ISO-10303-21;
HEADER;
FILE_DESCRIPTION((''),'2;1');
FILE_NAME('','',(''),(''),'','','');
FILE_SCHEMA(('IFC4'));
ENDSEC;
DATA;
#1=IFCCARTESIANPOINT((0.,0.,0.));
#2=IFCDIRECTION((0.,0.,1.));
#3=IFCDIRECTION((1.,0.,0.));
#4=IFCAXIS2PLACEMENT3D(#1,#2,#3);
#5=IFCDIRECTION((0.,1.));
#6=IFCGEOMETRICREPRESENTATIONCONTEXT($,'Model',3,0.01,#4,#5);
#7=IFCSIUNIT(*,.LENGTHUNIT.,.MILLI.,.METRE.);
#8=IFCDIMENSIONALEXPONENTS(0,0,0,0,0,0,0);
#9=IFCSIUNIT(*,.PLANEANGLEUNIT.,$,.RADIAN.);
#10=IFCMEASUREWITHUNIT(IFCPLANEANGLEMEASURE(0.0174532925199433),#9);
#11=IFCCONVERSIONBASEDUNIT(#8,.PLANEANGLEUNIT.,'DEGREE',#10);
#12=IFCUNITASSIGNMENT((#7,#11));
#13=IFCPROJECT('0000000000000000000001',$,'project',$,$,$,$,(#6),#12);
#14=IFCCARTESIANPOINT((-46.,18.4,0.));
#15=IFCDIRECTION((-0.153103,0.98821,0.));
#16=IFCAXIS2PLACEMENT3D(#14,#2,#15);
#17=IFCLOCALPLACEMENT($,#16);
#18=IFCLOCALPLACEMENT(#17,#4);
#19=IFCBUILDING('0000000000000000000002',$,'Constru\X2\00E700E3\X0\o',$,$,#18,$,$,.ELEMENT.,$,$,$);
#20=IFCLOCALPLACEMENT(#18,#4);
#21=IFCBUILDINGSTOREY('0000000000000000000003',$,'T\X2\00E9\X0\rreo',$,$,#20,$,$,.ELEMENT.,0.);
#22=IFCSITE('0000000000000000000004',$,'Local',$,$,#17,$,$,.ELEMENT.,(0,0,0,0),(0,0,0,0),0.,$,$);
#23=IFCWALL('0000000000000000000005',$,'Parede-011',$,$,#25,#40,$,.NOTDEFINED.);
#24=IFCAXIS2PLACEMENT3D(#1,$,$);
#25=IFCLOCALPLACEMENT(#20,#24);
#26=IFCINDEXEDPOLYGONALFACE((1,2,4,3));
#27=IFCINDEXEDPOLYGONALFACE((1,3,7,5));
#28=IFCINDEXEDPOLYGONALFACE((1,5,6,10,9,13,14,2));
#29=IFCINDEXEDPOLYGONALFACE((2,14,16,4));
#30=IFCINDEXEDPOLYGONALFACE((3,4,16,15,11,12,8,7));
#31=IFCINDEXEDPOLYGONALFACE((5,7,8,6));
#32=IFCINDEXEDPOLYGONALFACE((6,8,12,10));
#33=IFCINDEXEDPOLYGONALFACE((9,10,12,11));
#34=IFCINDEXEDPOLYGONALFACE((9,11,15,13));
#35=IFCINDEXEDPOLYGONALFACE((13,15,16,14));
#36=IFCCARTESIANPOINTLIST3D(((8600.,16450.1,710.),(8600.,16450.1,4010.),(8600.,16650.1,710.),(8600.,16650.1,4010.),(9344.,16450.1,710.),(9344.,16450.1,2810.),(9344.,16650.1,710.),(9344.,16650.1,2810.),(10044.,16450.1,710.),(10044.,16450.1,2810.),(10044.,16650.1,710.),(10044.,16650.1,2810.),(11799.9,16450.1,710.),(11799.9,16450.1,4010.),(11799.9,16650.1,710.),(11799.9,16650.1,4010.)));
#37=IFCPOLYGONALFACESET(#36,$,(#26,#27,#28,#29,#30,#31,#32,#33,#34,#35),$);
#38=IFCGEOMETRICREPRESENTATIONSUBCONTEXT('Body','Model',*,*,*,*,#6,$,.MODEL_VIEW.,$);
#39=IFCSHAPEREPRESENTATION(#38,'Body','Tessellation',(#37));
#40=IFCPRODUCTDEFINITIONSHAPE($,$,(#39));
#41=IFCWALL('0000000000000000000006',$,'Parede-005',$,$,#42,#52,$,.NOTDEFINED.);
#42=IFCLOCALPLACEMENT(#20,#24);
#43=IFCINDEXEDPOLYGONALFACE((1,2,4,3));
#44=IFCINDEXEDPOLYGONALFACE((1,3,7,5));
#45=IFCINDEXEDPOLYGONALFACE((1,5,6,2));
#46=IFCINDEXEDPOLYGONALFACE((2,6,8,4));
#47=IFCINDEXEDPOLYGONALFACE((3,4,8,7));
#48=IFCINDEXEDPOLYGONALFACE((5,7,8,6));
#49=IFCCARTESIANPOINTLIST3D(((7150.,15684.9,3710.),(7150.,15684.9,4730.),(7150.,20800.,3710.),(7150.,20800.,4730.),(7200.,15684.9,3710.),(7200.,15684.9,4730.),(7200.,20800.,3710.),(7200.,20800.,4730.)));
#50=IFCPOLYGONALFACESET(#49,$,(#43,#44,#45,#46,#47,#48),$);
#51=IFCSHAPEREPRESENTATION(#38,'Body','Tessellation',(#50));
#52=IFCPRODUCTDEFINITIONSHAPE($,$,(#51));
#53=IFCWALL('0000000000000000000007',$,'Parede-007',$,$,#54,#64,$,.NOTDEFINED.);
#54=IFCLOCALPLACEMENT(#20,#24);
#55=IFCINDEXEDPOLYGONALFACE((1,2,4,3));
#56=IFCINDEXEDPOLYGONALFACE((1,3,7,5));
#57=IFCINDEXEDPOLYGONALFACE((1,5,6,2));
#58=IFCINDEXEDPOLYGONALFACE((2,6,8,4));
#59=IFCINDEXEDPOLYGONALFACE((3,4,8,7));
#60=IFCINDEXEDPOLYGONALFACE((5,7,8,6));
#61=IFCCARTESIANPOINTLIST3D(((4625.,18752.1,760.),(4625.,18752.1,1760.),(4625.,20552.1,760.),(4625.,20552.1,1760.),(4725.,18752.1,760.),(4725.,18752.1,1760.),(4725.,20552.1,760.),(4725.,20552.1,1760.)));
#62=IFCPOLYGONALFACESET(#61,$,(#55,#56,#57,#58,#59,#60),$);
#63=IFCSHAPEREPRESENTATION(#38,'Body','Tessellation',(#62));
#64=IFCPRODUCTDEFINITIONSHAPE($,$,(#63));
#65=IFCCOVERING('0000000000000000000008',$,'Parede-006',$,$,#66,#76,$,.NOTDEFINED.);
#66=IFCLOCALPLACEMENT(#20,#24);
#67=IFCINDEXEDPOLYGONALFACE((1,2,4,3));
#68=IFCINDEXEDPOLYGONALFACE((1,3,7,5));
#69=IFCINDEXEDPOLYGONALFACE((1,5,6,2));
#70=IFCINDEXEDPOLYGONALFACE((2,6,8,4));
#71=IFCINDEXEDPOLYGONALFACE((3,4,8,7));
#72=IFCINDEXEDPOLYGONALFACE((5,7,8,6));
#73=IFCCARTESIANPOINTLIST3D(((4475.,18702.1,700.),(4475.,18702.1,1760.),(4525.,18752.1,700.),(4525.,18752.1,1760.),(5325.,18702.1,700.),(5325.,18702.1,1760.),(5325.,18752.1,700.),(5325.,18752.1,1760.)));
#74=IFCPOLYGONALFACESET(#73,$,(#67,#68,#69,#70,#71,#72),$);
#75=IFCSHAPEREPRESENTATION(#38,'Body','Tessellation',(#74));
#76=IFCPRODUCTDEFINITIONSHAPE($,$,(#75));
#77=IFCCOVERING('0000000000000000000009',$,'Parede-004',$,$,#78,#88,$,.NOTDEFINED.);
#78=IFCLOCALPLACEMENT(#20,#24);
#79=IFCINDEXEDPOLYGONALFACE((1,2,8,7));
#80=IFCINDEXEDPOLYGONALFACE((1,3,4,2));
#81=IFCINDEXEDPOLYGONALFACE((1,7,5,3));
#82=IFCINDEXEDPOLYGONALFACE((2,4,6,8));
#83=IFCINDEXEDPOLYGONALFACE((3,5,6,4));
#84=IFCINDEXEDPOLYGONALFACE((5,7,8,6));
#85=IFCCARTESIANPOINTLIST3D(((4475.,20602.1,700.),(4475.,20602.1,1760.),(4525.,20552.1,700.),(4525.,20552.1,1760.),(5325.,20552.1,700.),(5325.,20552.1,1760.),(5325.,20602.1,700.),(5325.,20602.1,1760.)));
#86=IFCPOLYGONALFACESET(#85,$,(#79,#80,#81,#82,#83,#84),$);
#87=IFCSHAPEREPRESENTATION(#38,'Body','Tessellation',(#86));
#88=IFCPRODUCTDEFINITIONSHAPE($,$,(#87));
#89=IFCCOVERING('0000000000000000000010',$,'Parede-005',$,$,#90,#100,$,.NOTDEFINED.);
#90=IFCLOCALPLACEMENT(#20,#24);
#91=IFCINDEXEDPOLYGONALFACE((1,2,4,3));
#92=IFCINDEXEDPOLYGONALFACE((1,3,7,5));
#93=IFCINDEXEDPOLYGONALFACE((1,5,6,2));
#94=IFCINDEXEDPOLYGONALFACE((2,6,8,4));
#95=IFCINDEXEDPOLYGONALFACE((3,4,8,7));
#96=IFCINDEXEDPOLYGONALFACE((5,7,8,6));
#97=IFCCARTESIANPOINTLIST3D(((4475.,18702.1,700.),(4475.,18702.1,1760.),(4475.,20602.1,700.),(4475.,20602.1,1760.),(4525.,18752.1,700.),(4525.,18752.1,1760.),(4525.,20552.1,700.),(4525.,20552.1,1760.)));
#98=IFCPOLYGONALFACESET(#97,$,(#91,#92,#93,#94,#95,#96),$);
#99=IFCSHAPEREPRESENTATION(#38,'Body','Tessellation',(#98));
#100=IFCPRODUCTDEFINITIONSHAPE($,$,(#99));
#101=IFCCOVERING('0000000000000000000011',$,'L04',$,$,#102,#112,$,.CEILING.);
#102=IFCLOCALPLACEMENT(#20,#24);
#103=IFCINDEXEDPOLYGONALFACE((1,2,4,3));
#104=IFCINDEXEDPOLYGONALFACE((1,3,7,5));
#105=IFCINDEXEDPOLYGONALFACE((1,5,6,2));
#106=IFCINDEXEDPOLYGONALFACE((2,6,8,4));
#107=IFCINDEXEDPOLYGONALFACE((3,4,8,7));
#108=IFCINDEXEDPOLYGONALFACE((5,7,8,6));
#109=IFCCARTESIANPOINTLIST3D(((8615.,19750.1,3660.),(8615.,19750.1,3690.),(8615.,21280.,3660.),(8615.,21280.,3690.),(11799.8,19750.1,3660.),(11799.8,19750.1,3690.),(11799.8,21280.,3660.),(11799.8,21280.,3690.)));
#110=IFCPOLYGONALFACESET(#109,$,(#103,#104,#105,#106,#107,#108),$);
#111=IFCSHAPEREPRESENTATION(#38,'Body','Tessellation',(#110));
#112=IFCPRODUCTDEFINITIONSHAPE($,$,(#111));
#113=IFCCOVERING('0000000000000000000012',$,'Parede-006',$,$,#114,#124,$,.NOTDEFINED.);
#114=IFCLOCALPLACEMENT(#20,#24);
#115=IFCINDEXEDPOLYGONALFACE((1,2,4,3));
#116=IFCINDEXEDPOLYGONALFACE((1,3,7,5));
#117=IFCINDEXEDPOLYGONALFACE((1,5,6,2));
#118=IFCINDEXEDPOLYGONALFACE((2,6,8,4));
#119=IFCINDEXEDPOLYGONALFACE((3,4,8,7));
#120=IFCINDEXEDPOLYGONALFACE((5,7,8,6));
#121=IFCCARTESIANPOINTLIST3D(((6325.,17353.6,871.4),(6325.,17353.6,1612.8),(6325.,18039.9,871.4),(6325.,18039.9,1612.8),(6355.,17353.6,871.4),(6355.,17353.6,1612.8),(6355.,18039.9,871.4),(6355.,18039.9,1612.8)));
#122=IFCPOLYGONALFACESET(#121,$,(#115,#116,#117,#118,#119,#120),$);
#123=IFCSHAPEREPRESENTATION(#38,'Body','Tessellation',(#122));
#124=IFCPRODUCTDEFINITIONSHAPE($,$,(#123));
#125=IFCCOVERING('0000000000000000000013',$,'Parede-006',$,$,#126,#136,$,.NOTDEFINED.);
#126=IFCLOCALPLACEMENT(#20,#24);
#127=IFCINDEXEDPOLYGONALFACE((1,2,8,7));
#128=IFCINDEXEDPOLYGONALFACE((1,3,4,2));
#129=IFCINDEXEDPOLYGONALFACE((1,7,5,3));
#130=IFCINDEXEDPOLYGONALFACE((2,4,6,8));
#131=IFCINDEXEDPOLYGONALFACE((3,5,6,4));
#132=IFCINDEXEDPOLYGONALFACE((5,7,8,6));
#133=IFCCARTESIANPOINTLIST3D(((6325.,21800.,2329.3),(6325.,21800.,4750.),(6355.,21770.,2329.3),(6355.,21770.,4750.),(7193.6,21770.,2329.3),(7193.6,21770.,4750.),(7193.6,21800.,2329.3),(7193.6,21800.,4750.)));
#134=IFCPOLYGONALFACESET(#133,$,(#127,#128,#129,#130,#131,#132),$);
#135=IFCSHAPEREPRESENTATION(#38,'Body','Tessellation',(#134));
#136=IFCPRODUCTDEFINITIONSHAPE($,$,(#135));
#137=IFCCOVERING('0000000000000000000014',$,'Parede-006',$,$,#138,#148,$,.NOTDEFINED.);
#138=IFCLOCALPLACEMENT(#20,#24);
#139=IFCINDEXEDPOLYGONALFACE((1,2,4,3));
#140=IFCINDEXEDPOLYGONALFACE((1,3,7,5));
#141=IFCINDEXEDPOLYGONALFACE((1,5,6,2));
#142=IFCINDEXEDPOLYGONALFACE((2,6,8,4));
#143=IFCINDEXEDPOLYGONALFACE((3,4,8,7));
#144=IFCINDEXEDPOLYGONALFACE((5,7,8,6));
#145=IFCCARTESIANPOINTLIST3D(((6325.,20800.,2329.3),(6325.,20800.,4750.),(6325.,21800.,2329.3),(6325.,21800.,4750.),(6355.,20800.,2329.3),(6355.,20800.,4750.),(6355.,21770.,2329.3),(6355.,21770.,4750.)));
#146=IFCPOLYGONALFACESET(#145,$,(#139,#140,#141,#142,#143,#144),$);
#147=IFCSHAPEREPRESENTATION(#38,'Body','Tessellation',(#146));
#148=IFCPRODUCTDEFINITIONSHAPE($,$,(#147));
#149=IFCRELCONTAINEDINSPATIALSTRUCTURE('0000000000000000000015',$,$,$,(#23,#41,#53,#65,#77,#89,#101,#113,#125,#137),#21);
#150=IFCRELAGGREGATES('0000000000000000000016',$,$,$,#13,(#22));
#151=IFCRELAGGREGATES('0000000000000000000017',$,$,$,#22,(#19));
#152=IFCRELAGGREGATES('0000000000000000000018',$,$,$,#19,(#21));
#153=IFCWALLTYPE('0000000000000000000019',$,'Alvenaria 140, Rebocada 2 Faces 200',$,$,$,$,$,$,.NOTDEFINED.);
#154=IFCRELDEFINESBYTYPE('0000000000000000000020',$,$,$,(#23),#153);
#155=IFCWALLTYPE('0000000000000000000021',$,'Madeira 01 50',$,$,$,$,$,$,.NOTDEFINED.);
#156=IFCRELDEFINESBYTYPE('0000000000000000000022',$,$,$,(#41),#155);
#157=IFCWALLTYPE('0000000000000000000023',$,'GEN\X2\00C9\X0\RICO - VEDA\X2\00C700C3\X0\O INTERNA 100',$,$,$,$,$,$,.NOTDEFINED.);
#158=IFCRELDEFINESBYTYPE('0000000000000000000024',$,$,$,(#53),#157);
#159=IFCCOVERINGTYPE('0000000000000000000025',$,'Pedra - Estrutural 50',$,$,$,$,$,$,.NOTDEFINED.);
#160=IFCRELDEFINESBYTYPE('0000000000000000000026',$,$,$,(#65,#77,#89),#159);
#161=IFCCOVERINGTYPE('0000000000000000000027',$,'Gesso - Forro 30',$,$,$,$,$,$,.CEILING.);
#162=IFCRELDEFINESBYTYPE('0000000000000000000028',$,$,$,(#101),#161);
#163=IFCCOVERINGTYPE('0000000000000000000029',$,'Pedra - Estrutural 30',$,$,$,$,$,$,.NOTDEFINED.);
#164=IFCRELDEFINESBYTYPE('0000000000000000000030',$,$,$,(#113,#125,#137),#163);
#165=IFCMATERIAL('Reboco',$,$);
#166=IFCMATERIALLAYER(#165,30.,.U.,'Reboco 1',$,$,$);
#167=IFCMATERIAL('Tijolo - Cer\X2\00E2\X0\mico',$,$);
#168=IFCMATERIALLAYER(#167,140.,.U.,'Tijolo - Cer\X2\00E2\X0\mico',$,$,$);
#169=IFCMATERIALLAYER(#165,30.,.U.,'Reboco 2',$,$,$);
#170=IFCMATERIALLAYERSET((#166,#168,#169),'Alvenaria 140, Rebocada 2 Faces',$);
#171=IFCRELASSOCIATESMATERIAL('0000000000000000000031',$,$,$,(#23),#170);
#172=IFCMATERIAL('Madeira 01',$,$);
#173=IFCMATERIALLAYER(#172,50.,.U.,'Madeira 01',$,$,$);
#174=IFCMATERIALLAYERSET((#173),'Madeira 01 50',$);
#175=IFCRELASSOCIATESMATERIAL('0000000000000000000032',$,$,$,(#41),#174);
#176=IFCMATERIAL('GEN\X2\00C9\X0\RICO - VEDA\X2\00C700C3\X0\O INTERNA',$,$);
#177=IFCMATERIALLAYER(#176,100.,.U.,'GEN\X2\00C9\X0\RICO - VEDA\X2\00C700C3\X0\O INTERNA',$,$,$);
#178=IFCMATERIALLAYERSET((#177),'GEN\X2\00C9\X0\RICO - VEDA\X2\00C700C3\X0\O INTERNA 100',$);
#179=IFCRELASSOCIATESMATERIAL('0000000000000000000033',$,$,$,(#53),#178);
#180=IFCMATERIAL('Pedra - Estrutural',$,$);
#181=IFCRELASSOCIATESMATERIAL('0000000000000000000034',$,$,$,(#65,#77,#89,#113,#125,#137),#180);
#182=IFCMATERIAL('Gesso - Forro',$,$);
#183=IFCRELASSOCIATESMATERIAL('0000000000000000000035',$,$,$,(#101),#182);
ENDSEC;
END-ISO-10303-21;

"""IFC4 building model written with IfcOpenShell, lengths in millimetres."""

from ifc_helpers import new_model, entity, si_unit, converted_unit, direction, frame, origin_with_axes, origin_2d_with_axis, place, context, subcontext, project, spatial, line, indexed_curve, rectangle, outline, extrude, material, layer, layer_set, layer_usage, type_object, element, save


model = new_model("IFC4")

# Units and contexts
model_context = context("Model", 3, precision=0.01, world=origin_with_axes(), true_north=direction((0.0, 1.0)))
body_context = subcontext(model_context, "Body", "Model", "MODEL_VIEW")
ifc_project = project(units=[si_unit("LENGTHUNIT", "METRE", prefix="MILLI"), converted_unit("PLANEANGLEUNIT", "DEGREE", entity("IfcPlaneAngleMeasure", 0.0174532925199433), si_unit("PLANEANGLEUNIT", "RADIAN"), dimensions=[0, 0, 0, 0, 0, 0, 0])], contexts=[model_context])

# Site, building, storey
site_placement = place(None, frame((-46.0, 18.4, 0.0), z_axis=(0.0, 0.0, 1.0), x_axis=(-0.153103, 0.98821, 0.0)))
site = spatial("IfcSite", under=ifc_project, at=site_placement, Name="Local", CompositionType="ELEMENT", RefLatitude=(0, 0, 0, 0), RefLongitude=(0, 0, 0, 0), RefElevation=0.0)
building_placement = place(site_placement, origin_with_axes())
building = spatial("IfcBuilding", under=site, at=building_placement, Name="Construção", CompositionType="ELEMENT")
storey_placement = place(building_placement, origin_with_axes())
storey = spatial("IfcBuildingStorey", under=building, at=storey_placement, Name="Térreo", CompositionType="ELEMENT", Elevation=0.0)

# Wall, opening
ifc_material_1 = material(Name="Reboco")
ifc_layer_1 = layer(ifc_material_1, 30.0, ventilated="UNKNOWN", Name="Reboco 1")
ifc_material_2 = material(Name="Tijolo - Cerâmico")
ifc_layer_2 = layer(ifc_material_2, 140.0, ventilated="UNKNOWN", Name="Tijolo - Cerâmico")
ifc_layer_3 = layer(ifc_material_1, 30.0, ventilated="UNKNOWN", Name="Reboco 2")
ifc_layer_set_1 = layer_set([ifc_layer_1, ifc_layer_2, ifc_layer_3], Name="Alvenaria 140, Rebocada 2 Faces")
ifc_layer_usage_1 = layer_usage(ifc_layer_set_1, "AXIS2", "NEGATIVE", 0.0)
wall_type_1 = type_object("IfcWallType", Name="Alvenaria 140, Rebocada 2 Faces 200", PredefinedType="NOTDEFINED")
wall_1_placement = place(storey_placement, frame((8400.0, 16650.1, 710.0), z_axis=(0.0, 0.0, 1.0), x_axis=(1.0, 0.0, 0.0)))
wall_1 = element("IfcWall", 1, at=wall_1_placement, inside=storey, type_object=wall_type_1, material=ifc_layer_usage_1, Name="Parede-011", PredefinedType="NOTDEFINED", context=body_context, shape_type="SweptSolid", body=[
    extrude(outline(indexed_curve([(200.0, -200.0), (3399.9, -200.0), (3399.9, 0.0), (200.0, 0.0)], segments=[line(1, 2, 3, 4, 1)])), origin_with_axes(), (0.0, 0.0, 1.0), 3300.0),
])
opening_1_placement = place(wall_1_placement, frame((1294.0, 0.0, 0.0), z_axis=(0.0, 0.0, 1.0), x_axis=(1.0, 0.0, 0.0)))
element("IfcOpeningElement", 2, at=opening_1_placement, cuts=wall_1, context=body_context, shape_type="SweptSolid", body=[
    extrude(rectangle(XDim=700.0, YDim=2100.0, at=origin_2d_with_axis()), frame((0.0, -200.0, 1050.0), z_axis=(0.0, 1.0, 0.0), x_axis=(-1.0, 0.0, 0.0)), (0.0, 0.0, 1.0), 600.0),
])

# Walls
ifc_material_3 = material(Name="Madeira 01")
ifc_layer_4 = layer(ifc_material_3, 50.0, ventilated="UNKNOWN", Name="Madeira 01")
ifc_layer_set_2 = layer_set([ifc_layer_4], Name="Madeira 01 50")
ifc_layer_usage_2 = layer_usage(ifc_layer_set_2, "AXIS2", "NEGATIVE", 50.0)
wall_type_2 = type_object("IfcWallType", Name="Madeira 01 50", PredefinedType="NOTDEFINED")
wall_2_placement = place(storey_placement, frame((7150.0, 20800.0, 3710.0), z_axis=(0.0, 0.0, 1.0), x_axis=(0.0, -1.0, 0.0)))
element("IfcWall", 3, at=wall_2_placement, inside=storey, type_object=wall_type_2, material=ifc_layer_usage_2, Name="Parede-005", PredefinedType="NOTDEFINED", context=body_context, shape_type="SweptSolid", body=[
    extrude(outline(indexed_curve([(0.0, 0.0), (5115.1, 0.0), (5115.1, 50.0), (0.0, 50.0)], segments=[line(1, 2, 3, 4, 1)])), origin_with_axes(), (0.0, 0.0, 1.0), 1020.0),
])
ifc_material_4 = material(Name="GENÉRICO - VEDAÇÃO INTERNA")
ifc_layer_5 = layer(ifc_material_4, 100.0, ventilated="UNKNOWN", Name="GENÉRICO - VEDAÇÃO INTERNA")
ifc_layer_set_3 = layer_set([ifc_layer_5], Name="GENÉRICO - VEDAÇÃO INTERNA 100")
ifc_layer_usage_3 = layer_usage(ifc_layer_set_3, "AXIS2", "POSITIVE", 0.0)
wall_type_3 = type_object("IfcWallType", Name="GENÉRICO - VEDAÇÃO INTERNA 100", PredefinedType="NOTDEFINED")
wall_3_placement = place(storey_placement, frame((4625.0, 20552.1, 760.0), z_axis=(0.0, 0.0, 1.0), x_axis=(0.0, -1.0, 0.0)))
element("IfcWall", 4, at=wall_3_placement, inside=storey, type_object=wall_type_3, material=ifc_layer_usage_3, Name="Parede-007", PredefinedType="NOTDEFINED", context=body_context, shape_type="SweptSolid", body=[
    extrude(outline(indexed_curve([(0.0, 0.0), (1800.0, 0.0), (1800.0, 100.0), (0.0, 100.0)], segments=[line(1, 2, 3, 4, 1)])), origin_with_axes(), (0.0, 0.0, 1.0), 1000.0),
])

# Coverings
ifc_material_5 = material(Name="Pedra - Estrutural")
covering_type_1 = type_object("IfcCoveringType", Name="Pedra - Estrutural 50", PredefinedType="NOTDEFINED")
covering_1_placement = place(storey_placement, frame((4475.0, 18702.1, 700.0), z_axis=(0.0, 0.0, 1.0), x_axis=(1.0, 0.0, 0.0)))
element("IfcCovering", 5, at=covering_1_placement, inside=storey, type_object=covering_type_1, material=ifc_material_5, Name="Parede-006", PredefinedType="NOTDEFINED", context=body_context, shape_type="SweptSolid", body=[
    extrude(outline(indexed_curve([(0.0, 0.0), (850.0, 0.0), (850.0, 50.0), (50.0, 50.0)], segments=[line(1, 2, 3, 4, 1)])), origin_with_axes(), (0.0, 0.0, 1.0), 1060.0),
])
covering_2_placement = place(storey_placement, frame((5325.0, 20602.1, 700.0), z_axis=(0.0, 0.0, 1.0), x_axis=(-1.0, 0.0, 0.0)))
element("IfcCovering", 6, at=covering_2_placement, inside=storey, type_object=covering_type_1, material=ifc_material_5, Name="Parede-004", PredefinedType="NOTDEFINED", context=body_context, shape_type="SweptSolid", body=[
    extrude(outline(indexed_curve([(0.0, 0.0), (850.0, 0.0), (800.0, 50.0), (0.0, 50.0)], segments=[line(1, 2, 3, 4, 1)])), origin_with_axes(), (0.0, 0.0, 1.0), 1060.0),
])
covering_3_placement = place(storey_placement, frame((4475.0, 20602.1, 700.0), z_axis=(0.0, 0.0, 1.0), x_axis=(0.0, -1.0, 0.0)))
element("IfcCovering", 7, at=covering_3_placement, inside=storey, type_object=covering_type_1, material=ifc_material_5, Name="Parede-005", PredefinedType="NOTDEFINED", context=body_context, shape_type="SweptSolid", body=[
    extrude(outline(indexed_curve([(0.0, 0.0), (1900.0, 0.0), (1850.0, 50.0), (50.0, 50.0)], segments=[line(1, 2, 3, 4, 1)])), origin_with_axes(), (0.0, 0.0, 1.0), 1060.0),
])
ifc_material_6 = material(Name="Gesso - Forro")
covering_type_2 = type_object("IfcCoveringType", Name="Gesso - Forro 30", PredefinedType="CEILING")
covering_4_placement = place(storey_placement, frame((8615.0, 19750.1, 3690.0), z_axis=(0.0, 0.0, 1.0), x_axis=(1.0, 0.0, 0.0)))
element("IfcCovering", 8, at=covering_4_placement, inside=storey, type_object=covering_type_2, material=ifc_material_6, Name="L04", PredefinedType="CEILING", context=body_context, shape_type="SweptSolid", body=[
    extrude(outline(indexed_curve([(0.0, 0.0), (3184.9, 0.0), (3184.9, 1530.0), (0.0, 1530.0)], segments=[line(1, 2, 3, 4, 1)])), frame((0.0, 0.0, -30.0), z_axis=(0.0, 0.0, 1.0), x_axis=(1.0, 0.0, 0.0)), (0.0, 0.0, 1.0), 30.0),
])
covering_type_3 = type_object("IfcCoveringType", Name="Pedra - Estrutural 30", PredefinedType="NOTDEFINED")
covering_5_placement = place(storey_placement, frame((6325.0, 18039.9, 871.4), z_axis=(0.0, 0.0, 1.0), x_axis=(0.0, -1.0, 0.0)))
element("IfcCovering", 9, at=covering_5_placement, inside=storey, type_object=covering_type_3, material=ifc_material_5, Name="Parede-006", PredefinedType="NOTDEFINED", context=body_context, shape_type="SweptSolid", body=[
    extrude(outline(indexed_curve([(0.0, 0.0), (686.3, 0.0), (686.3, 30.0), (0.0, 30.0)], segments=[line(1, 2, 3, 4, 1)])), origin_with_axes(), (0.0, 0.0, 1.0), 741.4),
])
covering_6_placement = place(storey_placement, frame((6325.0, 21800.0, 2329.3), z_axis=(0.0, 0.0, 1.0), x_axis=(1.0, -0.000001, 0.0)))
element("IfcCovering", 10, at=covering_6_placement, inside=storey, type_object=covering_type_3, material=ifc_material_5, Name="Parede-006", PredefinedType="NOTDEFINED", context=body_context, shape_type="SweptSolid", body=[
    extrude(outline(indexed_curve([(30.0, -30.0), (868.6, -30.0), (868.6, 0.0), (0.0, 0.0)], segments=[line(1, 2, 3, 4, 1)])), origin_with_axes(), (0.0, 0.0, 1.0), 2420.7),
])
covering_7_placement = place(storey_placement, frame((6325.0, 21800.0, 2329.3), z_axis=(0.0, 0.0, 1.0), x_axis=(-0.000001, -1.0, 0.0)))
element("IfcCovering", 11, at=covering_7_placement, inside=storey, type_object=covering_type_3, material=ifc_material_5, Name="Parede-006", PredefinedType="NOTDEFINED", context=body_context, shape_type="SweptSolid", body=[
    extrude(outline(indexed_curve([(0.0, 0.0), (1000.0, 0.0), (1000.0, 30.0), (30.0, 30.0)], segments=[line(1, 2, 3, 4, 1)])), origin_with_axes(), (0.0, 0.0, 1.0), 2420.7),
])

save(model, "model.ifc")
